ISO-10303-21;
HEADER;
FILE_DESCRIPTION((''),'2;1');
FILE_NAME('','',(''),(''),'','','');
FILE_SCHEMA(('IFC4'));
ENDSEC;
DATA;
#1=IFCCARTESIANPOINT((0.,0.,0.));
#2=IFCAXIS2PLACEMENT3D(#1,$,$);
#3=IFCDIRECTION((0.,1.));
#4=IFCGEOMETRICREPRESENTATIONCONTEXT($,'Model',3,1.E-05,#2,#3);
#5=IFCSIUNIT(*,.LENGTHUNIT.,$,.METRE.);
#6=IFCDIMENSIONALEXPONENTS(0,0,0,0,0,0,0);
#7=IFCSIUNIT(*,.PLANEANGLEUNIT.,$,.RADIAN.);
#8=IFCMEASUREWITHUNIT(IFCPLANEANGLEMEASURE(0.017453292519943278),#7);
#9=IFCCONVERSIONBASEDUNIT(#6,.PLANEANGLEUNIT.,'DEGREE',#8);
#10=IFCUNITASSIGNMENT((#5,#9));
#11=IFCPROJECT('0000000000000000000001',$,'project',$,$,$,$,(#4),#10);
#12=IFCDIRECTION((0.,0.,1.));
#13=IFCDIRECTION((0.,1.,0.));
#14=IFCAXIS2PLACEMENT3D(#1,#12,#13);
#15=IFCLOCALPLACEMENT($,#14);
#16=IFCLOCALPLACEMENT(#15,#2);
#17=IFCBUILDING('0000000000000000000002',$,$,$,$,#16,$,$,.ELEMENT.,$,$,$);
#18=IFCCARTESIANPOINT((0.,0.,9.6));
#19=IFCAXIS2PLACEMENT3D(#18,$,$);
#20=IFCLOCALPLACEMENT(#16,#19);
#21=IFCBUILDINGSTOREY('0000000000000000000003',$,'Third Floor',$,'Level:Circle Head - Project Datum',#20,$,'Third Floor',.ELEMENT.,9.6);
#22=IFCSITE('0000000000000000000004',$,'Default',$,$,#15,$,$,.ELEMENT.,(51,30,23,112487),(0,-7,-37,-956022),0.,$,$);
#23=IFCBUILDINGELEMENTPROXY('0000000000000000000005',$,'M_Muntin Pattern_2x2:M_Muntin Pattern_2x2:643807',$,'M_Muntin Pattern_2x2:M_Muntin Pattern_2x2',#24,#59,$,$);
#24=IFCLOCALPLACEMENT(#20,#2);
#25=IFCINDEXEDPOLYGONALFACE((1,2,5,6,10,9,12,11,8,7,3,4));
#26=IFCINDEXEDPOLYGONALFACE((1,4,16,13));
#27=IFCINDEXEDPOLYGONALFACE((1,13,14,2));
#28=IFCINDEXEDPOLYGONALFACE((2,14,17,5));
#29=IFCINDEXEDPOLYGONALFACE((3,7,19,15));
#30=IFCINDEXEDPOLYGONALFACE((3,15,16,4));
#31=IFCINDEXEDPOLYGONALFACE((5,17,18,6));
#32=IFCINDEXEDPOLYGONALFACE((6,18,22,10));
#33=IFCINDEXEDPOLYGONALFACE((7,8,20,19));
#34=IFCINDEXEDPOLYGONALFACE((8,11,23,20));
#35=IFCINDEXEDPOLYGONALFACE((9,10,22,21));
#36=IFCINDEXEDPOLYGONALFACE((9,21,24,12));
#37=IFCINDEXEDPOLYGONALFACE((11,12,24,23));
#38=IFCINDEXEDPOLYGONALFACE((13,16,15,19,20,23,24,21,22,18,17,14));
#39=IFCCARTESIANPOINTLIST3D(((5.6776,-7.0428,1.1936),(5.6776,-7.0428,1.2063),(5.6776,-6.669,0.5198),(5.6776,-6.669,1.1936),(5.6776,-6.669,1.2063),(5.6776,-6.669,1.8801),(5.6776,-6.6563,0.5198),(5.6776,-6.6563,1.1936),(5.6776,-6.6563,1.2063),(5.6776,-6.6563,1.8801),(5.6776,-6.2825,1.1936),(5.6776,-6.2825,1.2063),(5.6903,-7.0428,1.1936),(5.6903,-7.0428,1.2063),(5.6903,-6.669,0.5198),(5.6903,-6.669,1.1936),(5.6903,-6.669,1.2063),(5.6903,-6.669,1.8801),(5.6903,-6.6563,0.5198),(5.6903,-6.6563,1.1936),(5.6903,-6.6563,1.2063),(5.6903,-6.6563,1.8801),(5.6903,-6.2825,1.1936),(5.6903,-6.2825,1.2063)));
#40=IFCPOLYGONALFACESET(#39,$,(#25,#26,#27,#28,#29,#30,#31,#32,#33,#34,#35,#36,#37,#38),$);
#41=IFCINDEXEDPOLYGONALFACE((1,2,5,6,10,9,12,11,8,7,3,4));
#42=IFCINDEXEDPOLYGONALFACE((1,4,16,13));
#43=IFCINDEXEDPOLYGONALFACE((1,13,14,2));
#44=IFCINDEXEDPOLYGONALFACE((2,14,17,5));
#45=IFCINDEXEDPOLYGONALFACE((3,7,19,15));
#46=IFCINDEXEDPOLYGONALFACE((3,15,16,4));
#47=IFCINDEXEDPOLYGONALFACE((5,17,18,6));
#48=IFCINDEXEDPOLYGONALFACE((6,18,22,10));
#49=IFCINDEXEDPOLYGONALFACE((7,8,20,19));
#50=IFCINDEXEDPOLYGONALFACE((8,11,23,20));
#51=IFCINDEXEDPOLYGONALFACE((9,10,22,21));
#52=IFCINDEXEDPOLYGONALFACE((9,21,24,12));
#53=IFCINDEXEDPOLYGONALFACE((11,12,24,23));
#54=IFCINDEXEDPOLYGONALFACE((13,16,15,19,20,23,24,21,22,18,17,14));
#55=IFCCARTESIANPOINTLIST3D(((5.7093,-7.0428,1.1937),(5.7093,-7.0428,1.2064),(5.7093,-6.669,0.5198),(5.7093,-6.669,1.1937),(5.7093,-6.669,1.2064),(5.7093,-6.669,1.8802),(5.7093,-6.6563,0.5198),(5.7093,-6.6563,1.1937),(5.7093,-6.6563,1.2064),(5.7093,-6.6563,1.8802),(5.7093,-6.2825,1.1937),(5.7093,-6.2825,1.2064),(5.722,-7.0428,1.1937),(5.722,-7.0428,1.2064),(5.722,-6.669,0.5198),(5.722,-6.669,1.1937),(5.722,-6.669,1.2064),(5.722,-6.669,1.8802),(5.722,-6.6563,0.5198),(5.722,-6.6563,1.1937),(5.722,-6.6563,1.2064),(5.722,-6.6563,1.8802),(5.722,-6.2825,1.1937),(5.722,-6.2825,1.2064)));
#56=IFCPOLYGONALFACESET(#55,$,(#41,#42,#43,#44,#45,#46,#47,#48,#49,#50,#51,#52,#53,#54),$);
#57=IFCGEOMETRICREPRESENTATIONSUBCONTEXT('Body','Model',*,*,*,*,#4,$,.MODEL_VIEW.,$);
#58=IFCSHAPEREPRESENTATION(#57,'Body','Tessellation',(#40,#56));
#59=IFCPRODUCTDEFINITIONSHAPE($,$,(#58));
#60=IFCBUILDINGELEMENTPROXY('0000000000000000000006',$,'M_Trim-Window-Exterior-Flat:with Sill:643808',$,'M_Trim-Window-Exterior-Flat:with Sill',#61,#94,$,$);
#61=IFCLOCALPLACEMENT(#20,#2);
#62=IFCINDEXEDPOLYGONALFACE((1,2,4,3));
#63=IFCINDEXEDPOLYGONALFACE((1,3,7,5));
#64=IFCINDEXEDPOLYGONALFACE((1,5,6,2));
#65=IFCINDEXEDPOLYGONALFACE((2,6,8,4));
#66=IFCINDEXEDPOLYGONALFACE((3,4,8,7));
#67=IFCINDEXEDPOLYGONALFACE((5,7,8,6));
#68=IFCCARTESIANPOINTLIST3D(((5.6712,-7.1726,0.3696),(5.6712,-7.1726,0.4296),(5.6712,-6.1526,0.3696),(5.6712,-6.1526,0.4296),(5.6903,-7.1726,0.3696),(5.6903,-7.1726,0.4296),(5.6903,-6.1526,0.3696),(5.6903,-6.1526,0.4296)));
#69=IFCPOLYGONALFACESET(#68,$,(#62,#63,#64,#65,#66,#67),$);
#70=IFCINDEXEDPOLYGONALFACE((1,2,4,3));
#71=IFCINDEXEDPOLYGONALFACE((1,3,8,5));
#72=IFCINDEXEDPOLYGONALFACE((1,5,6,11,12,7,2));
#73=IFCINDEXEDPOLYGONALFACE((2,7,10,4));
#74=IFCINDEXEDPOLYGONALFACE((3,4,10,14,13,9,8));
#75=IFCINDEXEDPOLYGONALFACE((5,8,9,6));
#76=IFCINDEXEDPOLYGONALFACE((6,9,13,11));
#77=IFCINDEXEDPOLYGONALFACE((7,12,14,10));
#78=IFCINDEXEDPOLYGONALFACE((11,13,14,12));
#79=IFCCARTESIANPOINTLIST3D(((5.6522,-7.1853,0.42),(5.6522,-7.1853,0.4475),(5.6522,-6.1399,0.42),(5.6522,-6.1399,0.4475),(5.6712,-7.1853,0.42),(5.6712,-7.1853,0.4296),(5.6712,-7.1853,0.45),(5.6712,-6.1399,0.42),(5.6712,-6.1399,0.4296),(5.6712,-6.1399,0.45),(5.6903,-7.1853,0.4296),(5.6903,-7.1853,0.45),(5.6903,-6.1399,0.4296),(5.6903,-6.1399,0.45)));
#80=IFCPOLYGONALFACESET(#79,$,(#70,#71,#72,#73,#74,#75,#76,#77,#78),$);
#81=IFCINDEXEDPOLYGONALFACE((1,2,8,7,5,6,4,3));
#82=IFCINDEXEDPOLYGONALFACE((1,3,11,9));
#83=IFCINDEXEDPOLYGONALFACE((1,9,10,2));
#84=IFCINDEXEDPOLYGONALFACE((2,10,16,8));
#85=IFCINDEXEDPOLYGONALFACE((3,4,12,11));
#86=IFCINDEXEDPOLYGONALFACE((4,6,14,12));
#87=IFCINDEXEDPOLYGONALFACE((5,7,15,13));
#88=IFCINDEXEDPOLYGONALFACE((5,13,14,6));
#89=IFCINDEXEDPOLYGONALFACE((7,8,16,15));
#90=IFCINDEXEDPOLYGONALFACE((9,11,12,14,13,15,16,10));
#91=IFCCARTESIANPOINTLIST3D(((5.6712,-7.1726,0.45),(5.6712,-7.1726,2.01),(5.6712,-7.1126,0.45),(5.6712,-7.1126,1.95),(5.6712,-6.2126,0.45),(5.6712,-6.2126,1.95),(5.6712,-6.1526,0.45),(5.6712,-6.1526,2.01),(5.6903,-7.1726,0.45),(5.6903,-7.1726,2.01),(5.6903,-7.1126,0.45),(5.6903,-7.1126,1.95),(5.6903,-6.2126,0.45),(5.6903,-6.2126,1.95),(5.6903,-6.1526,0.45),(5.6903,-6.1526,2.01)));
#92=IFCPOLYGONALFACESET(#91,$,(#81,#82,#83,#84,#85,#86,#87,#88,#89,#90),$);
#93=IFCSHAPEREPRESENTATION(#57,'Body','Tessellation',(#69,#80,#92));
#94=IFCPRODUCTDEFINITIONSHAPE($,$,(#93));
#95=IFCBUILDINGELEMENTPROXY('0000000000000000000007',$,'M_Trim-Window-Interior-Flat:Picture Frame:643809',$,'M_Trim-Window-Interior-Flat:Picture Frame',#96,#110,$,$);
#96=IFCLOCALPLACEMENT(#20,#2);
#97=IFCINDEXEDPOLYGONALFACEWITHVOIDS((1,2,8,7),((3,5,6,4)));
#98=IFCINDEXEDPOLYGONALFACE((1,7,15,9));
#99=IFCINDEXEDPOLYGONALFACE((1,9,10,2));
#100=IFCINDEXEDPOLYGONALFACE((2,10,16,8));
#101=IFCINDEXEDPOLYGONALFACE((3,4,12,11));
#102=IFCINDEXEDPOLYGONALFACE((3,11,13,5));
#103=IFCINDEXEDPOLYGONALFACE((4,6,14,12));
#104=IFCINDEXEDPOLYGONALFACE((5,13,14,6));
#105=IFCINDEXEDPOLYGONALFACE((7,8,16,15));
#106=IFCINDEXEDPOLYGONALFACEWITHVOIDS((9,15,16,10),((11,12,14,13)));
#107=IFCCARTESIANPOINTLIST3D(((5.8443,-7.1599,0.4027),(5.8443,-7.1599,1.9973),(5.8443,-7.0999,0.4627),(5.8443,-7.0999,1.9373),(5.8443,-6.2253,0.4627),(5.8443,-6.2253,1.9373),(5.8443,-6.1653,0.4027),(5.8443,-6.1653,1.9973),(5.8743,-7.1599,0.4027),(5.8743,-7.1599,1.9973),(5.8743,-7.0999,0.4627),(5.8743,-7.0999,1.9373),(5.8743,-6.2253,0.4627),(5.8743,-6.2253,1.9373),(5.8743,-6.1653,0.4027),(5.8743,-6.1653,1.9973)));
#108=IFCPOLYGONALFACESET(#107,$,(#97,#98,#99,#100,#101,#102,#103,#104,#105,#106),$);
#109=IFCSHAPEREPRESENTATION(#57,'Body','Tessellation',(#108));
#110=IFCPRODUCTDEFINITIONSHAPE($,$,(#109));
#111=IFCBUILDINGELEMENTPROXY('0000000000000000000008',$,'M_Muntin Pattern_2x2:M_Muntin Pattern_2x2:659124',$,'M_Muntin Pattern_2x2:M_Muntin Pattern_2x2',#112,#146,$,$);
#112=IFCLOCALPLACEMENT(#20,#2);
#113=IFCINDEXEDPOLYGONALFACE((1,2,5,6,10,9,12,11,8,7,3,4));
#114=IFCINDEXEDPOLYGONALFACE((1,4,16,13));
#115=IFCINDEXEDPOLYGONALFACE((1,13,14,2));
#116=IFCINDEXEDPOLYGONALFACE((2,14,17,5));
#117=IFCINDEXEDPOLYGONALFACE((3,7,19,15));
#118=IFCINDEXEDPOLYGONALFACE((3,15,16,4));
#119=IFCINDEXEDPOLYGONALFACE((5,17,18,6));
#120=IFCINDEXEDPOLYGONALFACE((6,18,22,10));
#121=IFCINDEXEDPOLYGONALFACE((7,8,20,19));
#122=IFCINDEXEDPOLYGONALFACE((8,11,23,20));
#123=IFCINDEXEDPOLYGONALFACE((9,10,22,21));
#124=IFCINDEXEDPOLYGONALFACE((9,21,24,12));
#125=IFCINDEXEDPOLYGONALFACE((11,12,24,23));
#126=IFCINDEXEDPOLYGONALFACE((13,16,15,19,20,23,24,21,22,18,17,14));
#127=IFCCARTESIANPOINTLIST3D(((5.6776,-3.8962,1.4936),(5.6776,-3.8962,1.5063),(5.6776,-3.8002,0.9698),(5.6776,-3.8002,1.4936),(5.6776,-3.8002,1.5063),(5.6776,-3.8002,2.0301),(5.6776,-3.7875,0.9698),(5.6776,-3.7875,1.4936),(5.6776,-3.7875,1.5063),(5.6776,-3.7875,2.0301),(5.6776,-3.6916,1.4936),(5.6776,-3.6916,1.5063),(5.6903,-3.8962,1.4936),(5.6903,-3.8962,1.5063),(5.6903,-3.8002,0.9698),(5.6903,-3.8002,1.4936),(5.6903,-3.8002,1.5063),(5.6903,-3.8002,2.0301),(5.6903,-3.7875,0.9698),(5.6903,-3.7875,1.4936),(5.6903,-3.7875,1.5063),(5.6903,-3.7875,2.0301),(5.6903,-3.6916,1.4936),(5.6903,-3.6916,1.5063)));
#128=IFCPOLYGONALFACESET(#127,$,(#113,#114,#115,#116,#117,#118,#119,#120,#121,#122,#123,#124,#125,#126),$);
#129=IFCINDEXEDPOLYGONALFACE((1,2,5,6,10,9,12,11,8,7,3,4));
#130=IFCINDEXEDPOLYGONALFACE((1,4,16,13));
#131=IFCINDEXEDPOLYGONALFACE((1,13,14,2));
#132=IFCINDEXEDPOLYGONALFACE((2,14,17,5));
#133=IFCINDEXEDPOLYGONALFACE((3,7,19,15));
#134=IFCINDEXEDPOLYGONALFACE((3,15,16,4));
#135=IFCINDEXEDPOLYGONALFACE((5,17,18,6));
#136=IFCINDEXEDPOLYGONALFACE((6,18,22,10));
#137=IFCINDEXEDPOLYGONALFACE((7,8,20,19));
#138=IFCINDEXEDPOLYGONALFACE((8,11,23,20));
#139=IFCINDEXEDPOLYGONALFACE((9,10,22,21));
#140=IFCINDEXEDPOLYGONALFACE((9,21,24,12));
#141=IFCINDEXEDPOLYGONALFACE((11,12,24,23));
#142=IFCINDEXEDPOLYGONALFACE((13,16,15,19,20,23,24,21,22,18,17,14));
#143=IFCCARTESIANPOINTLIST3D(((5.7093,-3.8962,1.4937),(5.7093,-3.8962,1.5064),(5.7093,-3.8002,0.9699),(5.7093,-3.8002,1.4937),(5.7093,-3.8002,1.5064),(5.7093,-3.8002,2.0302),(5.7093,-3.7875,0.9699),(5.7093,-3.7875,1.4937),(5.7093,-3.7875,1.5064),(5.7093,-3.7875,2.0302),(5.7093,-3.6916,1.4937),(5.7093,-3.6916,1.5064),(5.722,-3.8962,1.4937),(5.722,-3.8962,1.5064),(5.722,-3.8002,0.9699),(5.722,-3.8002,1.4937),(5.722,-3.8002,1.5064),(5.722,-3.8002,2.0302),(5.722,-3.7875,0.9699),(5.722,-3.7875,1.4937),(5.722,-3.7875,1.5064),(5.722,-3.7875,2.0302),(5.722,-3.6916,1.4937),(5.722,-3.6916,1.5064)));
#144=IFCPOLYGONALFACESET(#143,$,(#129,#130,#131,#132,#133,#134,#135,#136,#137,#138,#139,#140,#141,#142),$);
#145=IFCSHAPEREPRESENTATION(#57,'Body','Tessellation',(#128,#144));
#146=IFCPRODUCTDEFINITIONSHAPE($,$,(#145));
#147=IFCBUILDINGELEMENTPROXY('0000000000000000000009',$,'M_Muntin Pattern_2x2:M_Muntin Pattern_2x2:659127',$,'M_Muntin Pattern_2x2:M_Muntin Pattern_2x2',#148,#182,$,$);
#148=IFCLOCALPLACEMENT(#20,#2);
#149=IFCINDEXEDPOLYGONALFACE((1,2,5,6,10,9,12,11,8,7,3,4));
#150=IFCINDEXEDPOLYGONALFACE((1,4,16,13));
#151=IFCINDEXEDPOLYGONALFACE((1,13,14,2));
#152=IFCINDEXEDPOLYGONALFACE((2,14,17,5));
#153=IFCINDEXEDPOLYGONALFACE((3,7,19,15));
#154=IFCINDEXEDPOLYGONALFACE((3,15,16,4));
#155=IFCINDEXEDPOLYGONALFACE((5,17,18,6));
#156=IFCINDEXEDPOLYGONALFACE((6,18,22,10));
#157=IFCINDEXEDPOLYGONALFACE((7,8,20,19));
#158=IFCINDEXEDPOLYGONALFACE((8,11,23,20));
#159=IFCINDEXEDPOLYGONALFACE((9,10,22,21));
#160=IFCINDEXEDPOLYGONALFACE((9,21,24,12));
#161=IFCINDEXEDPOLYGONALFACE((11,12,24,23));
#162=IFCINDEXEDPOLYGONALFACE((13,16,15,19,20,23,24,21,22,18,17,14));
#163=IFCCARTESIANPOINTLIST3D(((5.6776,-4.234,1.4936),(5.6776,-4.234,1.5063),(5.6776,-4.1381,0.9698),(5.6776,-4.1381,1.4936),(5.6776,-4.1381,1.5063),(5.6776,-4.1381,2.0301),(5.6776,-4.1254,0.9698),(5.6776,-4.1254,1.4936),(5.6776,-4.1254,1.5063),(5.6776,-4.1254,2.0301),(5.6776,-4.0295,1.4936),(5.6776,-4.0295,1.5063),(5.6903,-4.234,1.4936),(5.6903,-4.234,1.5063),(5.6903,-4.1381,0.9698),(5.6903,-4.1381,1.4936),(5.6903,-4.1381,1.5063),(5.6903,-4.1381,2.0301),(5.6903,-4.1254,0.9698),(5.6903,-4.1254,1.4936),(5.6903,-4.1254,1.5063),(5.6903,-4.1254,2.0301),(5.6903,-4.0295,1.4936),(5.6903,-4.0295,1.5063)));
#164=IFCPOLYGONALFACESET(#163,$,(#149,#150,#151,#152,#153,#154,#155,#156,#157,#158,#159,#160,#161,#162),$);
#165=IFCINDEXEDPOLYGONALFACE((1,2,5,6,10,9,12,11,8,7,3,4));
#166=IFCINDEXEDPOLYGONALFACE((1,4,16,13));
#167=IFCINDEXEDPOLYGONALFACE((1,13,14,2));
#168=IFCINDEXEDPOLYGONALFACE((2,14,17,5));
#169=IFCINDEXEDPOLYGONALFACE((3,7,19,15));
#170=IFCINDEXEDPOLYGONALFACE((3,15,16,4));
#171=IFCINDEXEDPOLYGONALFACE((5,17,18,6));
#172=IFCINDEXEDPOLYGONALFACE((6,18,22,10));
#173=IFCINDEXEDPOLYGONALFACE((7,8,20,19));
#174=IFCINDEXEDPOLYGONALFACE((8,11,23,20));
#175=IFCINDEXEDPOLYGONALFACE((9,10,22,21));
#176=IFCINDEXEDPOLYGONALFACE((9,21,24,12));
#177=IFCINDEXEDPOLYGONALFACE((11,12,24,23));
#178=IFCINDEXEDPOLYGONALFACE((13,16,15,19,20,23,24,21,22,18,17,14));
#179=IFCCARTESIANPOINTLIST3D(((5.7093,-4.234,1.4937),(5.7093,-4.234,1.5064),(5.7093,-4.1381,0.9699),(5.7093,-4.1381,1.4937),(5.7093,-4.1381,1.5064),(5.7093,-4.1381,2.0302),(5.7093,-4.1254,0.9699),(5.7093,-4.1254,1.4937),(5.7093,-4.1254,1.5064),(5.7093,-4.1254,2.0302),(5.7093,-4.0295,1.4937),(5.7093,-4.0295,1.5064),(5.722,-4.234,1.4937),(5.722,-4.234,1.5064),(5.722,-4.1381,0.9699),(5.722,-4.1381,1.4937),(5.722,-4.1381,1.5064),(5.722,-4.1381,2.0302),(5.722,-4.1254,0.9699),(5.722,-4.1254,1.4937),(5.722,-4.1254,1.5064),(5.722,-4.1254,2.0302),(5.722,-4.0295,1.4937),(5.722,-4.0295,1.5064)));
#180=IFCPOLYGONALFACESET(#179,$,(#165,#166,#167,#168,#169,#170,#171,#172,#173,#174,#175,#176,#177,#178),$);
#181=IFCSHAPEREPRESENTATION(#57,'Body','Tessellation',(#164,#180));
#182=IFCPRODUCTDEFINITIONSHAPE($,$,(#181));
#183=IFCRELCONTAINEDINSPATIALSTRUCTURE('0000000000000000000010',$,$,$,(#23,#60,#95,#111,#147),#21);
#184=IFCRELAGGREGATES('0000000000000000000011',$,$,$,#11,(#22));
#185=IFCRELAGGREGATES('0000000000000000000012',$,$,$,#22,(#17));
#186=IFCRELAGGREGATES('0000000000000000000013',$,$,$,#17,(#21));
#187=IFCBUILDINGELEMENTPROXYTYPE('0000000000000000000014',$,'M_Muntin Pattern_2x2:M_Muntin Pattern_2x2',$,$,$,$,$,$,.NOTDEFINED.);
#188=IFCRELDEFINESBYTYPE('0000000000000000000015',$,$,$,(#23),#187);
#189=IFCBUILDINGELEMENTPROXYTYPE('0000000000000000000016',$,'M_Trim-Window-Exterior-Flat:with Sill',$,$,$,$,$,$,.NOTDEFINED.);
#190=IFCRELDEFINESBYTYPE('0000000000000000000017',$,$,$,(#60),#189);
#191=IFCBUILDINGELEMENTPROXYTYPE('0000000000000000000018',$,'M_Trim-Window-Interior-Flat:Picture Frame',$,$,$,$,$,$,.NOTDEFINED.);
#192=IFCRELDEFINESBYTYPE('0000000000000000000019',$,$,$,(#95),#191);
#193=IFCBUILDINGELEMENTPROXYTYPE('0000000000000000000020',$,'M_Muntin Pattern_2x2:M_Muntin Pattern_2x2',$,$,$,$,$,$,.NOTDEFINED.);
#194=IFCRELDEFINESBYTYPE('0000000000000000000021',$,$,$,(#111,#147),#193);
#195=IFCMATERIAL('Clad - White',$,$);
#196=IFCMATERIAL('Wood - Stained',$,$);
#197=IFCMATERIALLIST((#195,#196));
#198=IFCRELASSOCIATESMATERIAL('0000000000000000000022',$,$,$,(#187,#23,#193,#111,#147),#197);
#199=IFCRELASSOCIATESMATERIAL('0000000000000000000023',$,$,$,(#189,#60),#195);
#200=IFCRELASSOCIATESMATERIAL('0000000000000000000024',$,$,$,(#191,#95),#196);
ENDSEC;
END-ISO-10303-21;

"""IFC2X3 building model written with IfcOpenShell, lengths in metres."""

from ifc_helpers import new_model, entity, si_unit, converted_unit, direction, frame, frame_2d, origin, place, context, subcontext, project, spatial, polyline, rectangle, outline, extrude, source, transform, mapped, material, material_list, type_object, type_shapes, element, save


model = new_model("IFC2X3")

# Units and contexts
model_context = context("Model", 3, precision=1e-05, world=origin(), true_north=direction((0.0, 1.0)))
body_context = subcontext(model_context, "Body", "Model", "MODEL_VIEW")
ifc_project = project(units=[si_unit("LENGTHUNIT", "METRE"), converted_unit("PLANEANGLEUNIT", "DEGREE", entity("IfcPlaneAngleMeasure", 0.017453292519943278), si_unit("PLANEANGLEUNIT", "RADIAN"), dimensions=[0, 0, 0, 0, 0, 0, 0])], contexts=[model_context])

# Site, building, storey
site_placement = place(None, frame((0.0, 0.0, 0.0), z_axis=(0.0, 0.0, 1.0), x_axis=(0.0, 1.0, 0.0)))
site = spatial("IfcSite", under=ifc_project, at=site_placement, Name="Default", CompositionType="ELEMENT", RefLatitude=(51, 30, 23, 112487), RefLongitude=(0, -7, -37, -956022), RefElevation=0.0)
building_placement = place(site_placement, origin())
building = spatial("IfcBuilding", under=site, at=building_placement, CompositionType="ELEMENT")
storey_placement = place(building_placement, frame((0.0, 0.0, 9.6)))
storey = spatial("IfcBuildingStorey", under=building, at=storey_placement, Name="Third Floor", ObjectType="Level:Circle Head - Project Datum", LongName="Third Floor", CompositionType="ELEMENT", Elevation=9.6)

# Building element proxies
ifc_material_1 = material(Name="Clad - White")
ifc_material_2 = material(Name="Wood - Stained")
ifc_material_list = material_list([ifc_material_1, ifc_material_2])
building_element_proxy_type_1 = type_object("IfcBuildingElementProxyType", Name="M_Muntin Pattern_2x2:M_Muntin Pattern_2x2", PredefinedType="NOTDEFINED", material=ifc_material_list)
shared_shape_1 = source(origin(), body_context, "Body", "SweptSolid", [
    extrude(outline(polyline([(0.0064, -0.0064), (0.6801, -0.0064), (0.6801, 0.0063), (0.0064, 0.0063), (0.0064, 0.3802), (-0.0063, 0.3802), (-0.0063, 0.0063), (-0.6802, 0.0063), (-0.6802, -0.0064), (-0.0063, -0.0064), (-0.0063, -0.3801), (0.0064, -0.3801), (0.0064, -0.0064)])), frame((0.0, 0.0095, 0.6801), z_axis=(0.0, 1.0, 0.0), x_axis=(0.0, 0.0, 1.0)), (0.0, 0.0, 1.0), 0.0127),
    extrude(outline(polyline([(0.0064, -0.0064), (0.6802, -0.0064), (0.6802, 0.0063), (0.0064, 0.0063), (0.0064, 0.3802), (-0.0063, 0.3802), (-0.0063, 0.0063), (-0.6802, 0.0063), (-0.6802, -0.0064), (-0.0063, -0.0064), (-0.0063, -0.3801), (0.0064, -0.3801), (0.0064, -0.0064)])), frame((0.0, -0.0222, 0.6802), z_axis=(0.0, 1.0, 0.0), x_axis=(0.0, 0.0, 1.0)), (0.0, 0.0, 1.0), 0.0127),
])
type_shapes(building_element_proxy_type_1, [shared_shape_1])
proxy_1_placement = place(storey_placement, frame((5.6998, -6.6626, 0.5198), z_axis=(0.0, 0.0, 1.0), x_axis=(0.0, 1.0, 0.0)))
element("IfcBuildingElementProxy", 1, at=proxy_1_placement, inside=storey, type_object=building_element_proxy_type_1, material=ifc_material_list, Name="M_Muntin Pattern_2x2:M_Muntin Pattern_2x2:643807", ObjectType="M_Muntin Pattern_2x2:M_Muntin Pattern_2x2", context=body_context, shape_type="MappedRepresentation", body=[
    mapped(shared_shape_1, transform((0.0, 0.0, 0.0), scale=1.0)),
])
building_element_proxy_type_2 = type_object("IfcBuildingElementProxyType", Name="M_Trim-Window-Exterior-Flat:with Sill", PredefinedType="NOTDEFINED", material=ifc_material_1)
shared_shape_2 = source(origin(), body_context, "Body", "SweptSolid", [
    extrude(rectangle(XDim=1.02, YDim=0.06, at=frame_2d((0.0, 0.0), x_axis=(1.0, 0.0))), frame((0.0, -1.5504, 0.0), z_axis=(0.0, 0.0, 1.0), x_axis=(-1.0, 0.0, 0.0)), (0.0, 0.0, 1.0), 0.019),
    extrude(outline(polyline([(-0.019, -0.0152), (0.0, -0.0152), (0.0, -0.0057), (0.019, -0.0057), (0.019, 0.0148), (0.0, 0.0148), (-0.019, 0.0123), (-0.019, -0.0152)])), frame((-0.5227, -1.5148, 0.019), z_axis=(1.0, 0.0, 0.0), x_axis=(0.0, 0.0, -1.0)), (0.0, 0.0, 1.0), 1.0454),
    extrude(outline(polyline([(-0.795, -0.51), (0.765, -0.51), (0.765, -0.45), (-0.735, -0.45), (-0.735, 0.45), (0.765, 0.45), (0.765, 0.51), (-0.795, 0.51), (-0.795, -0.51)])), frame((0.0, -0.735, 0.0), z_axis=(0.0, 0.0, 1.0), x_axis=(0.0, -1.0, 0.0)), (0.0, 0.0, 1.0), 0.019),
])
type_shapes(building_element_proxy_type_2, [shared_shape_2])
proxy_2_placement = place(storey_placement, frame((5.6903, -6.6626, 1.95), z_axis=(-1.0, 0.0, 0.0), x_axis=(0.0, -1.0, 0.0)))
element("IfcBuildingElementProxy", 2, at=proxy_2_placement, inside=storey, type_object=building_element_proxy_type_2, material=ifc_material_1, Name="M_Trim-Window-Exterior-Flat:with Sill:643808", ObjectType="M_Trim-Window-Exterior-Flat:with Sill", context=body_context, shape_type="MappedRepresentation", body=[
    mapped(shared_shape_2, transform((0.0, 0.0, 0.0), scale=1.0)),
])
building_element_proxy_type_3 = type_object("IfcBuildingElementProxyType", Name="M_Trim-Window-Interior-Flat:Picture Frame", PredefinedType="NOTDEFINED", material=ifc_material_2)
shared_shape_3 = source(origin(), body_context, "Body", "SweptSolid", [
    extrude(outline(polyline([(-0.4973, -0.7973), (0.4973, -0.7973), (0.4973, 0.7973), (-0.4973, 0.7973), (-0.4973, -0.7973)]), holes=[polyline([(-0.4373, -0.7373), (-0.4373, 0.7373), (0.4373, 0.7373), (0.4373, -0.7373), (-0.4373, -0.7373)])]), frame((0.0, -0.75, 0.0), z_axis=(0.0, 0.0, 1.0), x_axis=(-1.0, 0.0, 0.0)), (0.0, 0.0, 1.0), 0.03),
])
type_shapes(building_element_proxy_type_3, [shared_shape_3])
proxy_3_placement = place(storey_placement, frame((5.8443, -6.6626, 1.95), z_axis=(1.0, 0.0, 0.0), x_axis=(0.0, 1.0, 0.0)))
element("IfcBuildingElementProxy", 3, at=proxy_3_placement, inside=storey, type_object=building_element_proxy_type_3, material=ifc_material_2, Name="M_Trim-Window-Interior-Flat:Picture Frame:643809", ObjectType="M_Trim-Window-Interior-Flat:Picture Frame", context=body_context, shape_type="MappedRepresentation", body=[
    mapped(shared_shape_3, transform((0.0, 0.0, 0.0), scale=1.0)),
])
building_element_proxy_type_4 = type_object("IfcBuildingElementProxyType", Name="M_Muntin Pattern_2x2:M_Muntin Pattern_2x2", PredefinedType="NOTDEFINED", material=ifc_material_list)
shared_shape_4 = source(origin(), body_context, "Body", "SweptSolid", [
    extrude(outline(polyline([(0.0064, -0.0064), (0.5301, -0.0064), (0.5301, 0.0063), (0.0064, 0.0063), (0.0064, 0.1023), (-0.0063, 0.1023), (-0.0063, 0.0063), (-0.5302, 0.0063), (-0.5302, -0.0064), (-0.0063, -0.0064), (-0.0063, -0.1023), (0.0064, -0.1023), (0.0064, -0.0064)])), frame((0.0, -0.0222, 0.5301), z_axis=(0.0, 1.0, 0.0), x_axis=(0.0, 0.0, 1.0)), (0.0, 0.0, 1.0), 0.0127),
    extrude(outline(polyline([(0.0064, -0.0064), (0.5302, -0.0064), (0.5302, 0.0063), (0.0064, 0.0063), (0.0064, 0.1023), (-0.0063, 0.1023), (-0.0063, 0.0063), (-0.5302, 0.0063), (-0.5302, -0.0064), (-0.0063, -0.0064), (-0.0063, -0.1023), (0.0064, -0.1023), (0.0064, -0.0064)])), frame((0.0, 0.0095, 0.5302), z_axis=(0.0, 1.0, 0.0), x_axis=(0.0, 0.0, 1.0)), (0.0, 0.0, 1.0), 0.0127),
])
type_shapes(building_element_proxy_type_4, [shared_shape_4])
for number, where, z_axis, x_axis, name in (
    (4, (5.6998, -3.7939, 0.9699), (0.0, 0.0, 1.0), (0.0, -1.0, 0.0), "M_Muntin Pattern_2x2:M_Muntin Pattern_2x2:659124"),
    (5, (5.6998, -4.1318, 0.9699), (0.0, 0.0, 1.0), (0.0, -1.0, 0.0), "M_Muntin Pattern_2x2:M_Muntin Pattern_2x2:659127"),
):
    element("IfcBuildingElementProxy", number, at=place(storey_placement, frame(where, z_axis=z_axis, x_axis=x_axis)), inside=storey, type_object=building_element_proxy_type_4, material=ifc_material_list, Name=name, ObjectType="M_Muntin Pattern_2x2:M_Muntin Pattern_2x2", context=body_context, shape_type="MappedRepresentation", body=[
        mapped(shared_shape_4, transform((0.0, 0.0, 0.0), scale=1.0)),
    ])

save(model, "model.ifc")
